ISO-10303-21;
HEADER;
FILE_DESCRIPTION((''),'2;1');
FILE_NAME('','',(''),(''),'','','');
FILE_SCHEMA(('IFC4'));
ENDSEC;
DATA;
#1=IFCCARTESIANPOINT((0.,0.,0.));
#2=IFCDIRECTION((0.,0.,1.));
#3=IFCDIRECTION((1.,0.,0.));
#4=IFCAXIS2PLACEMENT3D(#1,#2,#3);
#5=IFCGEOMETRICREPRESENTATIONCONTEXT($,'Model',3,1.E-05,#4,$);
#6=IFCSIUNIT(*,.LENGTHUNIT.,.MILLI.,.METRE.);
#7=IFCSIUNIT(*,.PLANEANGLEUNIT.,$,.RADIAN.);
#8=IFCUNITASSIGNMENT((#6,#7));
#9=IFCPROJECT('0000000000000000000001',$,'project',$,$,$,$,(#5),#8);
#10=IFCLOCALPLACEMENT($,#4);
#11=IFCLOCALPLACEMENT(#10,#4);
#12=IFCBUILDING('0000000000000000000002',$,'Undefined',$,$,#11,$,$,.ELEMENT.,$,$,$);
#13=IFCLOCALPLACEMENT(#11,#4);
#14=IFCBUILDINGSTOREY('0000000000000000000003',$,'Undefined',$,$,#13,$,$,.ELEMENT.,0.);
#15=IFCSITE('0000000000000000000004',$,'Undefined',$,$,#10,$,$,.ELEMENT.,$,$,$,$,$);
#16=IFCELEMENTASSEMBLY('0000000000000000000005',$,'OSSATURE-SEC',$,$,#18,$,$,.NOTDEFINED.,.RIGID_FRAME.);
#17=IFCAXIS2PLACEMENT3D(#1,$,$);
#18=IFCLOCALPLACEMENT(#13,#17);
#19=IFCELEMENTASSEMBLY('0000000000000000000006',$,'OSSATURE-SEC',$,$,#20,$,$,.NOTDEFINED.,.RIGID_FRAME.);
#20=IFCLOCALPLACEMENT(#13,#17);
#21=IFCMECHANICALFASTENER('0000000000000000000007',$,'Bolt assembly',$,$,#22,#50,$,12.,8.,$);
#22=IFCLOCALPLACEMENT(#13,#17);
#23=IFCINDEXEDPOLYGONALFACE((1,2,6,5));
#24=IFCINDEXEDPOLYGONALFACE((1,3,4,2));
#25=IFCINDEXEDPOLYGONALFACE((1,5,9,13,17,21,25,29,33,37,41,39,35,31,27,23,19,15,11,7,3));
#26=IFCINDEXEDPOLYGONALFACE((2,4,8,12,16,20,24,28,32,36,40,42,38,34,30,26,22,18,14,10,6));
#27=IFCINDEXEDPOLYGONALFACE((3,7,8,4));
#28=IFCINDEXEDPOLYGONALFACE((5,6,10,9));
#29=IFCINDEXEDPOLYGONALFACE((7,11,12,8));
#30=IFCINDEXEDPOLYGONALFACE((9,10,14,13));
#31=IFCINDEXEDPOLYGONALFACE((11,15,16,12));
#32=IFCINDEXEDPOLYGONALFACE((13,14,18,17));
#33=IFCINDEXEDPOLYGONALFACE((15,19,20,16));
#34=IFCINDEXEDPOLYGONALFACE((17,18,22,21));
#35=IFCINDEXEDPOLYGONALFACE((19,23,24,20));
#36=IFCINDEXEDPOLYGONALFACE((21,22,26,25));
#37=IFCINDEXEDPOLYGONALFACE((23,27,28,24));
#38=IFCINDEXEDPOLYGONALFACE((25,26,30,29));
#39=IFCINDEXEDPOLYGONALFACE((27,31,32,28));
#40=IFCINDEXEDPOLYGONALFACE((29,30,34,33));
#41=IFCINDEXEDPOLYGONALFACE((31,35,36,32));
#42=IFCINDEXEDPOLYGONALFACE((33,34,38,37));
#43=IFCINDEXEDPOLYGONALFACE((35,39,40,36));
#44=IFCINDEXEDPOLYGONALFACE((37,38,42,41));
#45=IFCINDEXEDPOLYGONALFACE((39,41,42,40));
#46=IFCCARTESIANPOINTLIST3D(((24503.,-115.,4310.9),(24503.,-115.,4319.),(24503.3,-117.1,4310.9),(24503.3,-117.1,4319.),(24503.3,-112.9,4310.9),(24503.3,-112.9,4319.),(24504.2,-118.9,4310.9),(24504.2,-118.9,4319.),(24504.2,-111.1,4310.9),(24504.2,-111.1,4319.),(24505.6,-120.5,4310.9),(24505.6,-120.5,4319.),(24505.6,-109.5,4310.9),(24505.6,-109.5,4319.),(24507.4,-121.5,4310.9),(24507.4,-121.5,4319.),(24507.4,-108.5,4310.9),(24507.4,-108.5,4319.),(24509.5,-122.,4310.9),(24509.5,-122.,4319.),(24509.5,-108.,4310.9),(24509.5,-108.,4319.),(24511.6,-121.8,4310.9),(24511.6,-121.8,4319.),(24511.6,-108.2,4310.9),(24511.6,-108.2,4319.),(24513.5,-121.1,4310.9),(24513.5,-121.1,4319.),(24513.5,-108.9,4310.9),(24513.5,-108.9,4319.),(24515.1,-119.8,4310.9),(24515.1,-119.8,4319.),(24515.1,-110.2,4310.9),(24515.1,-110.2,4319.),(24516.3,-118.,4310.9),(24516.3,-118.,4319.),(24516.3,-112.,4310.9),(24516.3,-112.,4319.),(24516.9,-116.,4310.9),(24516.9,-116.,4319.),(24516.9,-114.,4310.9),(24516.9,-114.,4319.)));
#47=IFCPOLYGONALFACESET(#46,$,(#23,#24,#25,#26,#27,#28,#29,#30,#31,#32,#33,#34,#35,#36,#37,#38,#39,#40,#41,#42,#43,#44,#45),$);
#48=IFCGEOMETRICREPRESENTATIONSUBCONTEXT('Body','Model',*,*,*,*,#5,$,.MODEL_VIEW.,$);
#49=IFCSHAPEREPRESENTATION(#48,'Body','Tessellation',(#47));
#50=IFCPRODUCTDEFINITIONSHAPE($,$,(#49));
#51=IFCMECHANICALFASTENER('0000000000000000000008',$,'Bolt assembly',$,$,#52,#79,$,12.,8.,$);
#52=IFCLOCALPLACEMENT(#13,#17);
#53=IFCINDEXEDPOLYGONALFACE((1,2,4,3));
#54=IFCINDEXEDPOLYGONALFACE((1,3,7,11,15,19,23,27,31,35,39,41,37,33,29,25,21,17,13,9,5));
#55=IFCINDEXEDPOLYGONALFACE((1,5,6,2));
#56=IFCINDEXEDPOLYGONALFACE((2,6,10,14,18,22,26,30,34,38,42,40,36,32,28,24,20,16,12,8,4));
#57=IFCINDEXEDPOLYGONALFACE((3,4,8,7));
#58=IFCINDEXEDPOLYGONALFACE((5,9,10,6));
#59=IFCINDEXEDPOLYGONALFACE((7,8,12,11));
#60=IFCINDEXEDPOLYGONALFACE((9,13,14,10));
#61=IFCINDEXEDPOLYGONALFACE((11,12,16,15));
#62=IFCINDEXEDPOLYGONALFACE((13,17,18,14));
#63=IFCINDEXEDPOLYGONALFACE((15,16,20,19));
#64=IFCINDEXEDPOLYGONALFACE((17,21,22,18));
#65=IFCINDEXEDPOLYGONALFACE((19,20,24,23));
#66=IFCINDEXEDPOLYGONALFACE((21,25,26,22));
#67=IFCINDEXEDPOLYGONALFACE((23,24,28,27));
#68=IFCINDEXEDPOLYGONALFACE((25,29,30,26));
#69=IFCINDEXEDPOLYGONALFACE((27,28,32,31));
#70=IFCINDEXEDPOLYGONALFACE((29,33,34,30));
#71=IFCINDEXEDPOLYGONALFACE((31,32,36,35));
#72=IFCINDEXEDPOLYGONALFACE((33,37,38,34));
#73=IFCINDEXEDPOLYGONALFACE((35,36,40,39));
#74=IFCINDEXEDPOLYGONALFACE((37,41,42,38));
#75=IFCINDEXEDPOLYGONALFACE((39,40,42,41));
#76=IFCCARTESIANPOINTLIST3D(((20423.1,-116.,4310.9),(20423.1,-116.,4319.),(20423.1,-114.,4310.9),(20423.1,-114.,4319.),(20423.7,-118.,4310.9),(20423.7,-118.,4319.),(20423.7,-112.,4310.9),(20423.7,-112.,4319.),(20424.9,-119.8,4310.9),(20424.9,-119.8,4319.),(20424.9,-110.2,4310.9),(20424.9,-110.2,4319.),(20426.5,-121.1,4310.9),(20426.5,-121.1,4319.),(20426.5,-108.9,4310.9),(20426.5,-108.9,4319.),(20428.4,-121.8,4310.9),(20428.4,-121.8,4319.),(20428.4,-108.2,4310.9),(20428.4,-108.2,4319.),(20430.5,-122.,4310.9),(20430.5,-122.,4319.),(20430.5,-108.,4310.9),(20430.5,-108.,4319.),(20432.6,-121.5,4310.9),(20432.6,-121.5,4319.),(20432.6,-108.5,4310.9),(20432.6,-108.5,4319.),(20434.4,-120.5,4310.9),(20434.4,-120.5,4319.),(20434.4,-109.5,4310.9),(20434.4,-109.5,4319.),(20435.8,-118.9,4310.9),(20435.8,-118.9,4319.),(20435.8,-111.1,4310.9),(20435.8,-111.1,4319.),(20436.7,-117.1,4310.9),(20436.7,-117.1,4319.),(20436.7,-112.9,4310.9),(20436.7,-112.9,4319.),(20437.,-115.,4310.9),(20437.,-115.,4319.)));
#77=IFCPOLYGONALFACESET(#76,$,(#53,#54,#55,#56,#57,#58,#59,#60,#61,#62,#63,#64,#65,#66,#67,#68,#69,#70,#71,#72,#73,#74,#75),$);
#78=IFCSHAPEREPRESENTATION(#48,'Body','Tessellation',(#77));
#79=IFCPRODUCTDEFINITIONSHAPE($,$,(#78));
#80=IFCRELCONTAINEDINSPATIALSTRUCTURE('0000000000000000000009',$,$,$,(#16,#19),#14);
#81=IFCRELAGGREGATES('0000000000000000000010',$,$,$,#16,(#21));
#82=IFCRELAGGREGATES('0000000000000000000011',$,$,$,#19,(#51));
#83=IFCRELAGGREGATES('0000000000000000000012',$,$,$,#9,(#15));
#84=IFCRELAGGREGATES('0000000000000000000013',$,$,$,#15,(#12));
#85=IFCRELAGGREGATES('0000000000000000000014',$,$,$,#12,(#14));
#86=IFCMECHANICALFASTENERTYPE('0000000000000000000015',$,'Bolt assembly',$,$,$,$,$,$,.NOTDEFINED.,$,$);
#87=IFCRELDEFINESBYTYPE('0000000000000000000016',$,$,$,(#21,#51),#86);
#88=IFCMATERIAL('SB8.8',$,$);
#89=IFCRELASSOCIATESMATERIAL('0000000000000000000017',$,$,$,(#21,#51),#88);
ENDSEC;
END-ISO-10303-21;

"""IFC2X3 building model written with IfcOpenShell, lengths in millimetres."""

from ifc_helpers import new_model, si_unit, frame, origin_with_axes, origin_2d_with_axis, place, context, subcontext, project, spatial, circle, extrude, source, transform, mapped, material, type_object, element, aggregate, save


model = new_model("IFC2X3")

# Units and contexts
model_context = context("Model", 3, precision=1e-05, world=origin_with_axes())
body_context = subcontext(model_context, "Body", "Model", "MODEL_VIEW")
ifc_project = project(units=[si_unit("LENGTHUNIT", "METRE", prefix="MILLI"), si_unit("PLANEANGLEUNIT", "RADIAN")], contexts=[model_context])

# Site, building, storey
site_placement = place(None, origin_with_axes())
site = spatial("IfcSite", under=ifc_project, at=site_placement, Name="Undefined", CompositionType="ELEMENT")
building_placement = place(site_placement, origin_with_axes())
building = spatial("IfcBuilding", under=site, at=building_placement, Name="Undefined", CompositionType="ELEMENT")
storey_placement = place(building_placement, origin_with_axes())
storey = spatial("IfcBuildingStorey", under=building, at=storey_placement, Name="Undefined", CompositionType="ELEMENT", Elevation=0.0)

# Element assembly
assembly_1_placement = place(storey_placement, origin_with_axes())
assembly_1 = element("IfcElementAssembly", 1, at=assembly_1_placement, inside=storey, Name="OSSATURE-SEC", AssemblyPlace="NOTDEFINED", PredefinedType="RIGID_FRAME")

# Element assembly
assembly_2_placement = place(storey_placement, origin_with_axes())
assembly_2 = element("IfcElementAssembly", 2, at=assembly_2_placement, inside=storey, Name="OSSATURE-SEC", AssemblyPlace="NOTDEFINED", PredefinedType="RIGID_FRAME")

# Mechanical fasteners
ifc_material_1 = material(Name="SB8.8")
mechanical_fastener_type = type_object("IfcMechanicalFastenerType", Name="Bolt assembly")
shared_shape_1 = source(origin_with_axes(), body_context, "Body", "SweptSolid", [
    extrude(circle(Radius=7.0, at=origin_2d_with_axis()), frame((0.0, 1.0, 0.0), z_axis=(0.0, 1.0, 0.0), x_axis=(1.0, 0.0, 0.0)), (0.0, 0.0, 1.0), 8.1),
])
mechanical_fastener_1_placement = place(assembly_1_placement, frame((24510.0, -115.0, 4320.0), z_axis=(0.0, -1.0, 0.0), x_axis=(-1.0, 0.0, 0.0)))
mechanical_fastener_1 = element("IfcMechanicalFastener", 3, at=mechanical_fastener_1_placement, type_object=mechanical_fastener_type, material=ifc_material_1, Name="Bolt assembly", NominalDiameter=12.0, NominalLength=8.0, context=body_context, shape_type="MappedRepresentation", body=[
    mapped(shared_shape_1, transform((0.0, 0.0, 0.0))),
])
mechanical_fastener_2_placement = place(assembly_2_placement, frame((20430.0, -115.0, 4320.0), z_axis=(0.0, 1.0, 0.0), x_axis=(1.0, 0.0, 0.0)))
mechanical_fastener_2 = element("IfcMechanicalFastener", 4, at=mechanical_fastener_2_placement, type_object=mechanical_fastener_type, material=ifc_material_1, Name="Bolt assembly", NominalDiameter=12.0, NominalLength=8.0, context=body_context, shape_type="MappedRepresentation", body=[
    mapped(shared_shape_1, transform((0.0, 0.0, 0.0))),
])
aggregate(assembly_1, [mechanical_fastener_1])
aggregate(assembly_2, [mechanical_fastener_2])

save(model, "model.ifc")
